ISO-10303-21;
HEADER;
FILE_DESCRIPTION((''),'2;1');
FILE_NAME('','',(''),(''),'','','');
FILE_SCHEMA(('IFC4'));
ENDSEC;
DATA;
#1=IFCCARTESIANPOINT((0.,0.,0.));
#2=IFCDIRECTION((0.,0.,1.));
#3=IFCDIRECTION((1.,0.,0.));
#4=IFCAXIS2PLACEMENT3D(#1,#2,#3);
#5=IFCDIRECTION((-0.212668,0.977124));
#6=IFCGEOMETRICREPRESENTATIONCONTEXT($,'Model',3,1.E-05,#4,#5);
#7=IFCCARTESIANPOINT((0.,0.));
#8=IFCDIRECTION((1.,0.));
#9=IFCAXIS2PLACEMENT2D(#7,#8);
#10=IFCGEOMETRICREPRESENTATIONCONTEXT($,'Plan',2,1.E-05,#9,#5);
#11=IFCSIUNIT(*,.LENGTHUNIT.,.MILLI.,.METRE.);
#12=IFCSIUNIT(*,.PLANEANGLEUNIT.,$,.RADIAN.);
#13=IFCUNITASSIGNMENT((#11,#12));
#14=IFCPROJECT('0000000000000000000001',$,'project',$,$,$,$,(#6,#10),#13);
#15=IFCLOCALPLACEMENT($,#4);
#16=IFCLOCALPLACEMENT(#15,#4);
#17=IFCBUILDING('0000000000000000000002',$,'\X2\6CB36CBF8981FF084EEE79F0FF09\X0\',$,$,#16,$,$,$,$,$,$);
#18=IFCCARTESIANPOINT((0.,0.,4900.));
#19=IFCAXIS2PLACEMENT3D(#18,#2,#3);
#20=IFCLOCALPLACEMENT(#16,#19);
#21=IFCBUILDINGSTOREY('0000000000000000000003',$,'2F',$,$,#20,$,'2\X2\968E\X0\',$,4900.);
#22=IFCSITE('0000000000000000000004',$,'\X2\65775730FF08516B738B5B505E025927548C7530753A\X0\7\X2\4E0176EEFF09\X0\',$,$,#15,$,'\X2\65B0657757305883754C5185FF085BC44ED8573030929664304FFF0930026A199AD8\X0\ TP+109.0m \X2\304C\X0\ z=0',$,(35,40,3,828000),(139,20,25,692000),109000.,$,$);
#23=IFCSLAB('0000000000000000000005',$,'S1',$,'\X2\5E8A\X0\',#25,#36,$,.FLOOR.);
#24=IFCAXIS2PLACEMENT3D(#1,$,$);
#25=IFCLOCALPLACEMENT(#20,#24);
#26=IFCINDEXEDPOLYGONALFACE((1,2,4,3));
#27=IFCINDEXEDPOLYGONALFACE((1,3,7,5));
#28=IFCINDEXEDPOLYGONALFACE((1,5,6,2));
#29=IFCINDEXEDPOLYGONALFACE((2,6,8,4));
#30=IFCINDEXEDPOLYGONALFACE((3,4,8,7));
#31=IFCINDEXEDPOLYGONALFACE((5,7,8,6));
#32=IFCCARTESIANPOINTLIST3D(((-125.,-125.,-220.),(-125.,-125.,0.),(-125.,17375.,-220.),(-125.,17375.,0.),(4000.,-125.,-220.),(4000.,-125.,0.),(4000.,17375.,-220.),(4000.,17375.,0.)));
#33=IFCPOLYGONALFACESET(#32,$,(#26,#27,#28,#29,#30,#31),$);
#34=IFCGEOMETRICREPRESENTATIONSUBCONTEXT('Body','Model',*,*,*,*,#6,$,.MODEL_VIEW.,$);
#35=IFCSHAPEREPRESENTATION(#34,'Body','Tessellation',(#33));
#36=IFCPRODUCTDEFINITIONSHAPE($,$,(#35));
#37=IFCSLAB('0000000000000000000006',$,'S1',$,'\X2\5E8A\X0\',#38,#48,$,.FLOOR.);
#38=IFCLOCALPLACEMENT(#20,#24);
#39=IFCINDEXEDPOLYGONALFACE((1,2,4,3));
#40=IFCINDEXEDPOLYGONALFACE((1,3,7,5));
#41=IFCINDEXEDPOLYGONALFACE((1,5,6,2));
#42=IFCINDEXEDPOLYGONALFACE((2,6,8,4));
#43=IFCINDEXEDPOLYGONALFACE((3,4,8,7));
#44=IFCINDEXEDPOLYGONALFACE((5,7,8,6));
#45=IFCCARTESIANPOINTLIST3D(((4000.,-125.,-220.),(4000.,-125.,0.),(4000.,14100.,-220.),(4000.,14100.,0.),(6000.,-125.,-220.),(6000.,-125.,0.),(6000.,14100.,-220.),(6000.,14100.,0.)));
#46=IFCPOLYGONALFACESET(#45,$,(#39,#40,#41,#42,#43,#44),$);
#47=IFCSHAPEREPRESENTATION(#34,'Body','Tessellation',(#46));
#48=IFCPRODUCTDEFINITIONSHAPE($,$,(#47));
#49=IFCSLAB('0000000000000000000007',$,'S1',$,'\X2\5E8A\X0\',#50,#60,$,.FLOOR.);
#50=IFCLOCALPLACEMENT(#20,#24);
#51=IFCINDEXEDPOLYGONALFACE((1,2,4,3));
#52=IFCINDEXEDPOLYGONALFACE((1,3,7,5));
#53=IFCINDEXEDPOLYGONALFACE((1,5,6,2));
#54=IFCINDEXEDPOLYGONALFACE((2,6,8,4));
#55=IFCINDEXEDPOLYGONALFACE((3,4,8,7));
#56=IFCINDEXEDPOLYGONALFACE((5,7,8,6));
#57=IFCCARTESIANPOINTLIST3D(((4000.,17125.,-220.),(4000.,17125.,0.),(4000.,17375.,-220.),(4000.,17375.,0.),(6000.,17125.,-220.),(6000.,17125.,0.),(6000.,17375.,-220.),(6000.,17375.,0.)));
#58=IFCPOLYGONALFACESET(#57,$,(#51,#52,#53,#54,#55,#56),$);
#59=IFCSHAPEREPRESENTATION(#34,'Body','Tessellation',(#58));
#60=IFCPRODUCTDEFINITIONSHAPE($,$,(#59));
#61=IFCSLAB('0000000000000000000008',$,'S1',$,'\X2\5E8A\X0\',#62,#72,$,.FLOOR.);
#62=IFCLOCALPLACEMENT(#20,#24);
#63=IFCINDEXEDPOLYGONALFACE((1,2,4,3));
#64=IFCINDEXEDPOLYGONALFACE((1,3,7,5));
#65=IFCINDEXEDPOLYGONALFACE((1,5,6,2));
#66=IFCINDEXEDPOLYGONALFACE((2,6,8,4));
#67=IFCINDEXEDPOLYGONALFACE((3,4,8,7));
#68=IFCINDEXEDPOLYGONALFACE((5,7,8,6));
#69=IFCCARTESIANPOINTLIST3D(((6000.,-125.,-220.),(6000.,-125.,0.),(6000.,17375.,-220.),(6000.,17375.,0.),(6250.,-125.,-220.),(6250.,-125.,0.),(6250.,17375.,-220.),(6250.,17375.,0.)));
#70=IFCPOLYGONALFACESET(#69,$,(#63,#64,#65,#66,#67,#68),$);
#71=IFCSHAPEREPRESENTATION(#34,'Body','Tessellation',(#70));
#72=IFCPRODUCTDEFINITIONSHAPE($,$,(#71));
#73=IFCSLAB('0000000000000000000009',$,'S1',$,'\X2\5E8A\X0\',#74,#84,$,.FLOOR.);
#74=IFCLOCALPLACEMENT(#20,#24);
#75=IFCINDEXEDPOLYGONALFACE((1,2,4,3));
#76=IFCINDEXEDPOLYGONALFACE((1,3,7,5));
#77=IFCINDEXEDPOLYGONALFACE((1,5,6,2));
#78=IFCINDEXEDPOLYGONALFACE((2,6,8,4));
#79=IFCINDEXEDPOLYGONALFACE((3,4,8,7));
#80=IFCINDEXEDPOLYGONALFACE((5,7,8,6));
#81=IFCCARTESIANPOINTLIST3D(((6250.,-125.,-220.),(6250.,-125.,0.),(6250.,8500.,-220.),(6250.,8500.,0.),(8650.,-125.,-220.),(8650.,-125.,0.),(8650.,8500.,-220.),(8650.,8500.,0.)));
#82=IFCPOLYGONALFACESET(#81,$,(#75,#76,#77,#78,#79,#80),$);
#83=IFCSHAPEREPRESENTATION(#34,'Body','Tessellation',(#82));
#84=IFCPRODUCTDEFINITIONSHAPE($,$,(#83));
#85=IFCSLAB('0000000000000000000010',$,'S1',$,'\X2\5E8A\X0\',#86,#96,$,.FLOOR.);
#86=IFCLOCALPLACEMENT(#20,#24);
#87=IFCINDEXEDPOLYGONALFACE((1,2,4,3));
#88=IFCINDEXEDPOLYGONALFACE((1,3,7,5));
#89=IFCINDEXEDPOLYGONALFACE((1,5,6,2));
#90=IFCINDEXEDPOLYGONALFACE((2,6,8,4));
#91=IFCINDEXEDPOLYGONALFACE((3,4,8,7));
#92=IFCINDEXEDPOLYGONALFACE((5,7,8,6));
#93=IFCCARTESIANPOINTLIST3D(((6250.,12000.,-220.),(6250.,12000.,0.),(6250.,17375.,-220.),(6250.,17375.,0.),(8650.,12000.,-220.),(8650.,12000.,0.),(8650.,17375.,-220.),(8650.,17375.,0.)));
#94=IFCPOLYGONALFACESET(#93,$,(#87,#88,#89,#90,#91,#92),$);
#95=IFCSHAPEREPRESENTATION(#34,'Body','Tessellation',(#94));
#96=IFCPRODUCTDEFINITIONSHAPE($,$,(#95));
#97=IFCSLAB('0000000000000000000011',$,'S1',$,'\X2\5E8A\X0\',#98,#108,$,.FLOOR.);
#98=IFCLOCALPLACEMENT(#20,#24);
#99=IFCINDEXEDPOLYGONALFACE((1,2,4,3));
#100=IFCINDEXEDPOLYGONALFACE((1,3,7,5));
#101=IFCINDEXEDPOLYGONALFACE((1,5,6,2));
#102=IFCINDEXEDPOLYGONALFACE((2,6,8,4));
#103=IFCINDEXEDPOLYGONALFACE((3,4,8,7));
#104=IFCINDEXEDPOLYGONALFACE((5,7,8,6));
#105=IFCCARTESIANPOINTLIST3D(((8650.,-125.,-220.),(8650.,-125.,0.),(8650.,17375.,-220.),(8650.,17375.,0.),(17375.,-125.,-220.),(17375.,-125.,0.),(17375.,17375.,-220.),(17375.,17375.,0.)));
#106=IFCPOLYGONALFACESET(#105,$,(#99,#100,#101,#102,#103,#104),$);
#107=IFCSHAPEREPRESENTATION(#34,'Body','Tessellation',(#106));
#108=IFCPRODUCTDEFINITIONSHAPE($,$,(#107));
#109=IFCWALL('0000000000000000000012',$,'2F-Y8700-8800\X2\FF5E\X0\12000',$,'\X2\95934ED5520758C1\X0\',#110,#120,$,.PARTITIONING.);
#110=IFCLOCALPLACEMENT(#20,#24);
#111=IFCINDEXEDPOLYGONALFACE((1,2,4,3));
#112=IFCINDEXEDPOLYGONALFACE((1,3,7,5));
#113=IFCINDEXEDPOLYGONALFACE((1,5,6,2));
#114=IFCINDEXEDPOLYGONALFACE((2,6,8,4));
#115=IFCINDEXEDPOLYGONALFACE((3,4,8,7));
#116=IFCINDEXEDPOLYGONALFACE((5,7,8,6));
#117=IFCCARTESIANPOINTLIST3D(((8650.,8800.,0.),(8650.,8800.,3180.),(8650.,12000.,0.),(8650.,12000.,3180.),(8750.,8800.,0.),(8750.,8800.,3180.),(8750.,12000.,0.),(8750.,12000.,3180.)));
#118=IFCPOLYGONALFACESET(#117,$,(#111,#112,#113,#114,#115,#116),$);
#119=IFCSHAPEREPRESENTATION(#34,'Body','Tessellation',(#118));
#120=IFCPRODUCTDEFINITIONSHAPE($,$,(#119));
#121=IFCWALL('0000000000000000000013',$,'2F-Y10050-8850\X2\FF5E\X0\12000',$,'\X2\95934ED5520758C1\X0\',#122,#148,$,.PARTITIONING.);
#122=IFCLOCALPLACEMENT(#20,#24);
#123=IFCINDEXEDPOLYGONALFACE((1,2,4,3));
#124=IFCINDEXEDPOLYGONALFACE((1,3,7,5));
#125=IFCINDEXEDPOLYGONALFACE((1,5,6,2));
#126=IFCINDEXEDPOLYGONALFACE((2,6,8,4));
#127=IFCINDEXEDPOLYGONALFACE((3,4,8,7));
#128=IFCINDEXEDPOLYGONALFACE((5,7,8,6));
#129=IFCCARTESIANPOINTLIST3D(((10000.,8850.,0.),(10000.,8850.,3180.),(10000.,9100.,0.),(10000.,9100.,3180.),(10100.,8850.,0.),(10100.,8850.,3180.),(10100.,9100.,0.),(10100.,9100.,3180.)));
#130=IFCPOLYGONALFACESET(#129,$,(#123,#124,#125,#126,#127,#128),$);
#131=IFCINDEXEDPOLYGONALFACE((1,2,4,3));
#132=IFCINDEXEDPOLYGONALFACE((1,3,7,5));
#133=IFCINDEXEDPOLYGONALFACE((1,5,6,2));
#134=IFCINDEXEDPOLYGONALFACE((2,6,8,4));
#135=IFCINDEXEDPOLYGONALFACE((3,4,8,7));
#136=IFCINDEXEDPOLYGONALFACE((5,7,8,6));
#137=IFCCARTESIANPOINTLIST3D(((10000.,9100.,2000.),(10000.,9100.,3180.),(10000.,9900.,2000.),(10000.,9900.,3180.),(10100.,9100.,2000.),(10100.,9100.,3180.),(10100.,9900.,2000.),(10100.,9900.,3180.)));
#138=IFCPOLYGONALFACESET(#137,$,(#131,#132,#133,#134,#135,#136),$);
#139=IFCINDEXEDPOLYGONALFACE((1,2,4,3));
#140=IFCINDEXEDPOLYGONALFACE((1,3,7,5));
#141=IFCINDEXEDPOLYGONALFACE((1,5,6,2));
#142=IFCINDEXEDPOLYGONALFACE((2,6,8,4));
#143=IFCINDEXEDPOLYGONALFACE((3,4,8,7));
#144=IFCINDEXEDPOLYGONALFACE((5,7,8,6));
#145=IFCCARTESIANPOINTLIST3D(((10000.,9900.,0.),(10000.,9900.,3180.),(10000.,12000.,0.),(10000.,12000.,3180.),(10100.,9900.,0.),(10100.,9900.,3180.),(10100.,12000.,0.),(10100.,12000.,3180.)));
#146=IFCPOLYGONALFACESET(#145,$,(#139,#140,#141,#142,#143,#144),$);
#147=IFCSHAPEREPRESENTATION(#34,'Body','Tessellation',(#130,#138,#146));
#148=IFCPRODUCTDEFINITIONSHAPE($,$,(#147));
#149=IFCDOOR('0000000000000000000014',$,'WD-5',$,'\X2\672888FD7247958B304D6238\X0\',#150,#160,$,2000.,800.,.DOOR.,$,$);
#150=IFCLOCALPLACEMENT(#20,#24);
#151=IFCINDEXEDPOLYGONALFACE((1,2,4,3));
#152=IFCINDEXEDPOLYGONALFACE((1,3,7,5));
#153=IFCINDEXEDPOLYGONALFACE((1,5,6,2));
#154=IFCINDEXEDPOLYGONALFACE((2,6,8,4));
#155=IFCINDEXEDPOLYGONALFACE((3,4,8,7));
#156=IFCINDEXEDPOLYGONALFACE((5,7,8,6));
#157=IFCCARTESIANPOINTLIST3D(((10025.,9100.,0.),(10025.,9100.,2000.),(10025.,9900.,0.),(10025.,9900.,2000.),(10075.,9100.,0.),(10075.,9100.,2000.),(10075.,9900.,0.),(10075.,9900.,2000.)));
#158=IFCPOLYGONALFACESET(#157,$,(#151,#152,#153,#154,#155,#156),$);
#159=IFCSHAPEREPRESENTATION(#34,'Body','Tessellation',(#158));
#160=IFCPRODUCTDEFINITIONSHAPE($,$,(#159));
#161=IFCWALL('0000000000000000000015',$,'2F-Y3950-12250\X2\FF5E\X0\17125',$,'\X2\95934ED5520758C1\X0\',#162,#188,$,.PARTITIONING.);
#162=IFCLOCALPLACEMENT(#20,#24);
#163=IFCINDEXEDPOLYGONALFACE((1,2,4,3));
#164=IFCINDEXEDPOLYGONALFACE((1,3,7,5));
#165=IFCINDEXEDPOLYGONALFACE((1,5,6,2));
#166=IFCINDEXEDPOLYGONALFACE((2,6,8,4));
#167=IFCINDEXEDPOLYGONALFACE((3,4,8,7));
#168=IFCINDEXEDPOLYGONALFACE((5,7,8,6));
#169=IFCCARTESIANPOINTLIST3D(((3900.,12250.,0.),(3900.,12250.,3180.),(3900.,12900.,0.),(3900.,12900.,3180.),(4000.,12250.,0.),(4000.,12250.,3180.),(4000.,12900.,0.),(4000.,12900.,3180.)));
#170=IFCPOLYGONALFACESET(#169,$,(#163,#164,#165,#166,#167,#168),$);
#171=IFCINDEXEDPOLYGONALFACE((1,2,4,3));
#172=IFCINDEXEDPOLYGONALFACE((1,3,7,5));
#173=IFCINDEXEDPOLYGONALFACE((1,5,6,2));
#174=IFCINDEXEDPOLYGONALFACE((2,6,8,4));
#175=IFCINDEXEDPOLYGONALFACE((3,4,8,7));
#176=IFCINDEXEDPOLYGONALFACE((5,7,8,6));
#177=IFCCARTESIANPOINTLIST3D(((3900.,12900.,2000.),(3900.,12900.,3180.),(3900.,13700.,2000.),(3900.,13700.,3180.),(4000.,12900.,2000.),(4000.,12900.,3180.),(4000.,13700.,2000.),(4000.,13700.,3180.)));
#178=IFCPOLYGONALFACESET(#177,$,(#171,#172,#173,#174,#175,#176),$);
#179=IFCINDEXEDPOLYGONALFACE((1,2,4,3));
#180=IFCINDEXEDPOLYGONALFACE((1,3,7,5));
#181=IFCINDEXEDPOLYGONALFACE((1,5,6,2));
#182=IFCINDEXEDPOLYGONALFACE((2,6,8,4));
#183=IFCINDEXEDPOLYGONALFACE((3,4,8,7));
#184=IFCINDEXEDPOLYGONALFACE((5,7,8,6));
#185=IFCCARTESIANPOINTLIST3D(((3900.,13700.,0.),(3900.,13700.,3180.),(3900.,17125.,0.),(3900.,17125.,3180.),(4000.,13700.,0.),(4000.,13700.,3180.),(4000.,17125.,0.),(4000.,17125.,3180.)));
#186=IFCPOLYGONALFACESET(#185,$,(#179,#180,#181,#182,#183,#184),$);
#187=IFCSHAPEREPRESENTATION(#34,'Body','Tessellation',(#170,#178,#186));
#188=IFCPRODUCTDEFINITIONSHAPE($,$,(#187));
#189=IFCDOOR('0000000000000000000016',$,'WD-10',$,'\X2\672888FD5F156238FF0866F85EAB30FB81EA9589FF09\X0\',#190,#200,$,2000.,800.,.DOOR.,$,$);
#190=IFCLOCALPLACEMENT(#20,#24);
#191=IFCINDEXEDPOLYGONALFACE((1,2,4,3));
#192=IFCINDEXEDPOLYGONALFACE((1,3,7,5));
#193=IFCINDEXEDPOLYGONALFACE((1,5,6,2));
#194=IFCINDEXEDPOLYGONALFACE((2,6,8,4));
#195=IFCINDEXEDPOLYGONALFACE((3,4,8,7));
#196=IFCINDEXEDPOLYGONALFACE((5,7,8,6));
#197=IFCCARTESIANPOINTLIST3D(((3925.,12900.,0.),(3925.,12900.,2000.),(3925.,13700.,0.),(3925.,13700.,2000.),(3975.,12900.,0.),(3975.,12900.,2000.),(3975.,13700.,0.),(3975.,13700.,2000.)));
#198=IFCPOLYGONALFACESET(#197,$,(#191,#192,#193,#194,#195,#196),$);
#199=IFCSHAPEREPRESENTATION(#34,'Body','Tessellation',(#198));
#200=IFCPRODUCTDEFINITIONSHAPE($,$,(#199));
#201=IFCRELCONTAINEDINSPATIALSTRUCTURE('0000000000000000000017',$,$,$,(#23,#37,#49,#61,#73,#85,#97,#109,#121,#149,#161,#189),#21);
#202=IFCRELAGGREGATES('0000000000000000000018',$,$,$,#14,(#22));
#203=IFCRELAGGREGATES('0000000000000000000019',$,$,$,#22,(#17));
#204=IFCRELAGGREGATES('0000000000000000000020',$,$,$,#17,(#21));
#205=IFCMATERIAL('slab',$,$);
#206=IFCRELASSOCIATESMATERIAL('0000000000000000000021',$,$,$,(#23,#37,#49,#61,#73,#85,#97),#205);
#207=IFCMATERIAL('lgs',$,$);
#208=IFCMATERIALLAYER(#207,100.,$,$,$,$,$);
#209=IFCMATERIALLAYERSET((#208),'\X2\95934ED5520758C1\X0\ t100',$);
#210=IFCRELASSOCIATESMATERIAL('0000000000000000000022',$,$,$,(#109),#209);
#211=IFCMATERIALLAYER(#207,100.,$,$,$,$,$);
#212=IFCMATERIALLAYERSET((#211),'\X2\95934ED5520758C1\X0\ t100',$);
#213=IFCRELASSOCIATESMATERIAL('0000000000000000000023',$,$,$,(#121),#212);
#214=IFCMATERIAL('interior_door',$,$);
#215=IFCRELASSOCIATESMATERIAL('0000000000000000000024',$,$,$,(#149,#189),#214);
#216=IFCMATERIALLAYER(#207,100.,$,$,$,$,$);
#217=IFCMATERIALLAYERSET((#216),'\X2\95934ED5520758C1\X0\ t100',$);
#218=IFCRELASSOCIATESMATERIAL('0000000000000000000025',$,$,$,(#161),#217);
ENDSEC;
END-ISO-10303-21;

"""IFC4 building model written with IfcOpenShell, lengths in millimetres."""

from ifc_helpers import new_model, si_unit, direction, frame, frame_2d, origin, origin_with_axes, origin_2d_with_axis, place, context, subcontext, project, spatial, rectangle, extrude, material, layer, layer_set, layer_usage, element, fill, save


model = new_model("IFC4")

# Units and contexts
model_context = context("Model", 3, precision=1e-05, world=origin_with_axes(), true_north=direction((-0.212668, 0.977124)))
plan_context = context("Plan", 2, precision=1e-05, world=origin_2d_with_axis(), true_north=direction((-0.212668, 0.977124)))
body_context = subcontext(model_context, "Body", "Model", "MODEL_VIEW")
ifc_project = project(units=[si_unit("LENGTHUNIT", "METRE", prefix="MILLI"), si_unit("PLANEANGLEUNIT", "RADIAN")], contexts=[model_context, plan_context])

# Site, building, storey
site_placement = place(None, origin_with_axes())
site = spatial("IfcSite", under=ifc_project, at=site_placement, Name="敷地（八王子市大和田町7丁目）", LongName="新敷地境界内（寄付地を除く）。標高 TP+109.0m が z=0", RefLatitude=(35, 40, 3, 828000), RefLongitude=(139, 20, 25, 692000), RefElevation=109000.0)
building_placement = place(site_placement, origin_with_axes())
building = spatial("IfcBuilding", under=site, at=building_placement, Name="河沿要（仮称）")
storey_placement = place(building_placement, frame((0.0, 0.0, 4900.0), z_axis=(0.0, 0.0, 1.0), x_axis=(1.0, 0.0, 0.0)))
storey = spatial("IfcBuildingStorey", under=building, at=storey_placement, Name="2F", LongName="2階", Elevation=4900.0)

# Slabs
ifc_material_1 = material(Name="slab")
slab_1_placement = place(storey_placement, origin_with_axes())
element("IfcSlab", 1, at=slab_1_placement, inside=storey, material=ifc_material_1, Name="S1", ObjectType="床", PredefinedType="FLOOR", context=body_context, shape_type="SweptSolid", body=[
    extrude(rectangle(XDim=4125.0, YDim=17500.0, at=frame_2d((1937.5, 8625.0))), frame((0.0, 0.0, -220.0)), (0.0, 0.0, 1.0), 220.0),
])
slab_2_placement = place(storey_placement, origin_with_axes())
element("IfcSlab", 2, at=slab_2_placement, inside=storey, material=ifc_material_1, Name="S1", ObjectType="床", PredefinedType="FLOOR", context=body_context, shape_type="SweptSolid", body=[
    extrude(rectangle(XDim=2000.0, YDim=14225.0, at=frame_2d((5000.0, 6987.5))), frame((0.0, 0.0, -220.0)), (0.0, 0.0, 1.0), 220.0),
])
slab_3_placement = place(storey_placement, origin_with_axes())
element("IfcSlab", 3, at=slab_3_placement, inside=storey, material=ifc_material_1, Name="S1", ObjectType="床", PredefinedType="FLOOR", context=body_context, shape_type="SweptSolid", body=[
    extrude(rectangle(XDim=2000.0, YDim=250.0, at=frame_2d((5000.0, 17250.0))), frame((0.0, 0.0, -220.0)), (0.0, 0.0, 1.0), 220.0),
])
slab_4_placement = place(storey_placement, origin_with_axes())
element("IfcSlab", 4, at=slab_4_placement, inside=storey, material=ifc_material_1, Name="S1", ObjectType="床", PredefinedType="FLOOR", context=body_context, shape_type="SweptSolid", body=[
    extrude(rectangle(XDim=250.0, YDim=17500.0, at=frame_2d((6125.0, 8625.0))), frame((0.0, 0.0, -220.0)), (0.0, 0.0, 1.0), 220.0),
])
slab_5_placement = place(storey_placement, origin_with_axes())
element("IfcSlab", 5, at=slab_5_placement, inside=storey, material=ifc_material_1, Name="S1", ObjectType="床", PredefinedType="FLOOR", context=body_context, shape_type="SweptSolid", body=[
    extrude(rectangle(XDim=2400.0, YDim=8625.0, at=frame_2d((7450.0, 4187.5))), frame((0.0, 0.0, -220.0)), (0.0, 0.0, 1.0), 220.0),
])
slab_6_placement = place(storey_placement, origin_with_axes())
element("IfcSlab", 6, at=slab_6_placement, inside=storey, material=ifc_material_1, Name="S1", ObjectType="床", PredefinedType="FLOOR", context=body_context, shape_type="SweptSolid", body=[
    extrude(rectangle(XDim=2400.0, YDim=5375.0, at=frame_2d((7450.0, 14687.5))), frame((0.0, 0.0, -220.0)), (0.0, 0.0, 1.0), 220.0),
])
slab_7_placement = place(storey_placement, origin_with_axes())
element("IfcSlab", 7, at=slab_7_placement, inside=storey, material=ifc_material_1, Name="S1", ObjectType="床", PredefinedType="FLOOR", context=body_context, shape_type="SweptSolid", body=[
    extrude(rectangle(XDim=8725.0, YDim=17500.0, at=frame_2d((13012.5, 8625.0))), frame((0.0, 0.0, -220.0)), (0.0, 0.0, 1.0), 220.0),
])

# Wall
ifc_material_2 = material(Name="lgs")
ifc_layer_1 = layer(ifc_material_2, 100.0)
ifc_layer_set_1 = layer_set([ifc_layer_1], Name="間仕切壁 t100")
ifc_layer_usage_1 = layer_usage(ifc_layer_set_1, "AXIS2", "POSITIVE", 0.0)
wall_1_placement = place(storey_placement, origin_with_axes())
element("IfcWall", 8, at=wall_1_placement, inside=storey, material=ifc_layer_usage_1, Name="2F-Y8700-8800～12000", ObjectType="間仕切壁", PredefinedType="PARTITIONING", context=body_context, shape_type="SweptSolid", body=[
    extrude(rectangle(XDim=100.0, YDim=3200.0, at=frame_2d((8700.0, 10400.0))), origin(), (0.0, 0.0, 1.0), 3180.0),
])

# Walls, openings, doors
ifc_layer_2 = layer(ifc_material_2, 100.0)
ifc_layer_set_2 = layer_set([ifc_layer_2], Name="間仕切壁 t100")
ifc_layer_usage_2 = layer_usage(ifc_layer_set_2, "AXIS2", "POSITIVE", 0.0)
wall_2_placement = place(storey_placement, origin_with_axes())
wall_2 = element("IfcWall", 9, at=wall_2_placement, inside=storey, material=ifc_layer_usage_2, Name="2F-Y10050-8850～12000", ObjectType="間仕切壁", PredefinedType="PARTITIONING", context=body_context, shape_type="SweptSolid", body=[
    extrude(rectangle(XDim=100.0, YDim=250.0, at=frame_2d((10050.0, 8975.0))), origin(), (0.0, 0.0, 1.0), 3180.0),
    extrude(rectangle(XDim=100.0, YDim=800.0, at=frame_2d((10050.0, 9500.0))), frame((0.0, 0.0, 2000.0)), (0.0, 0.0, 1.0), 1180.0),
    extrude(rectangle(XDim=100.0, YDim=2100.0, at=frame_2d((10050.0, 10950.0))), origin(), (0.0, 0.0, 1.0), 3180.0),
])
opening_1_placement = place(storey_placement, origin_with_axes())
opening_1 = element("IfcOpeningElement", 10, at=opening_1_placement, inside=storey, cuts=wall_2, PredefinedType="OPENING", context=body_context, shape_type="SweptSolid", body=[
    extrude(rectangle(XDim=150.0, YDim=800.0, at=frame_2d((10050.0, 9500.0))), origin(), (0.0, 0.0, 1.0), 2000.0),
])
ifc_material_3 = material(Name="interior_door")
door_1_placement = place(storey_placement, origin_with_axes())
door_1 = element("IfcDoor", 11, at=door_1_placement, inside=storey, material=ifc_material_3, Name="WD-5", ObjectType="木製片開き戸", OverallHeight=2000.0, OverallWidth=800.0, PredefinedType="DOOR", context=body_context, shape_type="SweptSolid", body=[
    extrude(rectangle(XDim=50.0, YDim=800.0, at=frame_2d((10050.0, 9500.0))), origin(), (0.0, 0.0, 1.0), 2000.0),
])
fill(opening_1, door_1)
ifc_layer_3 = layer(ifc_material_2, 100.0)
ifc_layer_set_3 = layer_set([ifc_layer_3], Name="間仕切壁 t100")
ifc_layer_usage_3 = layer_usage(ifc_layer_set_3, "AXIS2", "POSITIVE", 0.0)
wall_3_placement = place(storey_placement, origin_with_axes())
wall_3 = element("IfcWall", 12, at=wall_3_placement, inside=storey, material=ifc_layer_usage_3, Name="2F-Y3950-12250～17125", ObjectType="間仕切壁", PredefinedType="PARTITIONING", context=body_context, shape_type="SweptSolid", body=[
    extrude(rectangle(XDim=100.0, YDim=650.0, at=frame_2d((3950.0, 12575.0))), origin(), (0.0, 0.0, 1.0), 3180.0),
    extrude(rectangle(XDim=100.0, YDim=800.0, at=frame_2d((3950.0, 13300.0))), frame((0.0, 0.0, 2000.0)), (0.0, 0.0, 1.0), 1180.0),
    extrude(rectangle(XDim=100.0, YDim=3425.0, at=frame_2d((3950.0, 15412.5))), origin(), (0.0, 0.0, 1.0), 3180.0),
])
opening_2_placement = place(storey_placement, origin_with_axes())
opening_2 = element("IfcOpeningElement", 13, at=opening_2_placement, inside=storey, cuts=wall_3, PredefinedType="OPENING", context=body_context, shape_type="SweptSolid", body=[
    extrude(rectangle(XDim=150.0, YDim=800.0, at=frame_2d((3950.0, 13300.0))), origin(), (0.0, 0.0, 1.0), 2000.0),
])
door_2_placement = place(storey_placement, origin_with_axes())
door_2 = element("IfcDoor", 14, at=door_2_placement, inside=storey, material=ifc_material_3, Name="WD-10", ObjectType="木製引戸（書庫・自閉）", OverallHeight=2000.0, OverallWidth=800.0, PredefinedType="DOOR", context=body_context, shape_type="SweptSolid", body=[
    extrude(rectangle(XDim=50.0, YDim=800.0, at=frame_2d((3950.0, 13300.0))), origin(), (0.0, 0.0, 1.0), 2000.0),
])
fill(opening_2, door_2)

save(model, "model.ifc")
